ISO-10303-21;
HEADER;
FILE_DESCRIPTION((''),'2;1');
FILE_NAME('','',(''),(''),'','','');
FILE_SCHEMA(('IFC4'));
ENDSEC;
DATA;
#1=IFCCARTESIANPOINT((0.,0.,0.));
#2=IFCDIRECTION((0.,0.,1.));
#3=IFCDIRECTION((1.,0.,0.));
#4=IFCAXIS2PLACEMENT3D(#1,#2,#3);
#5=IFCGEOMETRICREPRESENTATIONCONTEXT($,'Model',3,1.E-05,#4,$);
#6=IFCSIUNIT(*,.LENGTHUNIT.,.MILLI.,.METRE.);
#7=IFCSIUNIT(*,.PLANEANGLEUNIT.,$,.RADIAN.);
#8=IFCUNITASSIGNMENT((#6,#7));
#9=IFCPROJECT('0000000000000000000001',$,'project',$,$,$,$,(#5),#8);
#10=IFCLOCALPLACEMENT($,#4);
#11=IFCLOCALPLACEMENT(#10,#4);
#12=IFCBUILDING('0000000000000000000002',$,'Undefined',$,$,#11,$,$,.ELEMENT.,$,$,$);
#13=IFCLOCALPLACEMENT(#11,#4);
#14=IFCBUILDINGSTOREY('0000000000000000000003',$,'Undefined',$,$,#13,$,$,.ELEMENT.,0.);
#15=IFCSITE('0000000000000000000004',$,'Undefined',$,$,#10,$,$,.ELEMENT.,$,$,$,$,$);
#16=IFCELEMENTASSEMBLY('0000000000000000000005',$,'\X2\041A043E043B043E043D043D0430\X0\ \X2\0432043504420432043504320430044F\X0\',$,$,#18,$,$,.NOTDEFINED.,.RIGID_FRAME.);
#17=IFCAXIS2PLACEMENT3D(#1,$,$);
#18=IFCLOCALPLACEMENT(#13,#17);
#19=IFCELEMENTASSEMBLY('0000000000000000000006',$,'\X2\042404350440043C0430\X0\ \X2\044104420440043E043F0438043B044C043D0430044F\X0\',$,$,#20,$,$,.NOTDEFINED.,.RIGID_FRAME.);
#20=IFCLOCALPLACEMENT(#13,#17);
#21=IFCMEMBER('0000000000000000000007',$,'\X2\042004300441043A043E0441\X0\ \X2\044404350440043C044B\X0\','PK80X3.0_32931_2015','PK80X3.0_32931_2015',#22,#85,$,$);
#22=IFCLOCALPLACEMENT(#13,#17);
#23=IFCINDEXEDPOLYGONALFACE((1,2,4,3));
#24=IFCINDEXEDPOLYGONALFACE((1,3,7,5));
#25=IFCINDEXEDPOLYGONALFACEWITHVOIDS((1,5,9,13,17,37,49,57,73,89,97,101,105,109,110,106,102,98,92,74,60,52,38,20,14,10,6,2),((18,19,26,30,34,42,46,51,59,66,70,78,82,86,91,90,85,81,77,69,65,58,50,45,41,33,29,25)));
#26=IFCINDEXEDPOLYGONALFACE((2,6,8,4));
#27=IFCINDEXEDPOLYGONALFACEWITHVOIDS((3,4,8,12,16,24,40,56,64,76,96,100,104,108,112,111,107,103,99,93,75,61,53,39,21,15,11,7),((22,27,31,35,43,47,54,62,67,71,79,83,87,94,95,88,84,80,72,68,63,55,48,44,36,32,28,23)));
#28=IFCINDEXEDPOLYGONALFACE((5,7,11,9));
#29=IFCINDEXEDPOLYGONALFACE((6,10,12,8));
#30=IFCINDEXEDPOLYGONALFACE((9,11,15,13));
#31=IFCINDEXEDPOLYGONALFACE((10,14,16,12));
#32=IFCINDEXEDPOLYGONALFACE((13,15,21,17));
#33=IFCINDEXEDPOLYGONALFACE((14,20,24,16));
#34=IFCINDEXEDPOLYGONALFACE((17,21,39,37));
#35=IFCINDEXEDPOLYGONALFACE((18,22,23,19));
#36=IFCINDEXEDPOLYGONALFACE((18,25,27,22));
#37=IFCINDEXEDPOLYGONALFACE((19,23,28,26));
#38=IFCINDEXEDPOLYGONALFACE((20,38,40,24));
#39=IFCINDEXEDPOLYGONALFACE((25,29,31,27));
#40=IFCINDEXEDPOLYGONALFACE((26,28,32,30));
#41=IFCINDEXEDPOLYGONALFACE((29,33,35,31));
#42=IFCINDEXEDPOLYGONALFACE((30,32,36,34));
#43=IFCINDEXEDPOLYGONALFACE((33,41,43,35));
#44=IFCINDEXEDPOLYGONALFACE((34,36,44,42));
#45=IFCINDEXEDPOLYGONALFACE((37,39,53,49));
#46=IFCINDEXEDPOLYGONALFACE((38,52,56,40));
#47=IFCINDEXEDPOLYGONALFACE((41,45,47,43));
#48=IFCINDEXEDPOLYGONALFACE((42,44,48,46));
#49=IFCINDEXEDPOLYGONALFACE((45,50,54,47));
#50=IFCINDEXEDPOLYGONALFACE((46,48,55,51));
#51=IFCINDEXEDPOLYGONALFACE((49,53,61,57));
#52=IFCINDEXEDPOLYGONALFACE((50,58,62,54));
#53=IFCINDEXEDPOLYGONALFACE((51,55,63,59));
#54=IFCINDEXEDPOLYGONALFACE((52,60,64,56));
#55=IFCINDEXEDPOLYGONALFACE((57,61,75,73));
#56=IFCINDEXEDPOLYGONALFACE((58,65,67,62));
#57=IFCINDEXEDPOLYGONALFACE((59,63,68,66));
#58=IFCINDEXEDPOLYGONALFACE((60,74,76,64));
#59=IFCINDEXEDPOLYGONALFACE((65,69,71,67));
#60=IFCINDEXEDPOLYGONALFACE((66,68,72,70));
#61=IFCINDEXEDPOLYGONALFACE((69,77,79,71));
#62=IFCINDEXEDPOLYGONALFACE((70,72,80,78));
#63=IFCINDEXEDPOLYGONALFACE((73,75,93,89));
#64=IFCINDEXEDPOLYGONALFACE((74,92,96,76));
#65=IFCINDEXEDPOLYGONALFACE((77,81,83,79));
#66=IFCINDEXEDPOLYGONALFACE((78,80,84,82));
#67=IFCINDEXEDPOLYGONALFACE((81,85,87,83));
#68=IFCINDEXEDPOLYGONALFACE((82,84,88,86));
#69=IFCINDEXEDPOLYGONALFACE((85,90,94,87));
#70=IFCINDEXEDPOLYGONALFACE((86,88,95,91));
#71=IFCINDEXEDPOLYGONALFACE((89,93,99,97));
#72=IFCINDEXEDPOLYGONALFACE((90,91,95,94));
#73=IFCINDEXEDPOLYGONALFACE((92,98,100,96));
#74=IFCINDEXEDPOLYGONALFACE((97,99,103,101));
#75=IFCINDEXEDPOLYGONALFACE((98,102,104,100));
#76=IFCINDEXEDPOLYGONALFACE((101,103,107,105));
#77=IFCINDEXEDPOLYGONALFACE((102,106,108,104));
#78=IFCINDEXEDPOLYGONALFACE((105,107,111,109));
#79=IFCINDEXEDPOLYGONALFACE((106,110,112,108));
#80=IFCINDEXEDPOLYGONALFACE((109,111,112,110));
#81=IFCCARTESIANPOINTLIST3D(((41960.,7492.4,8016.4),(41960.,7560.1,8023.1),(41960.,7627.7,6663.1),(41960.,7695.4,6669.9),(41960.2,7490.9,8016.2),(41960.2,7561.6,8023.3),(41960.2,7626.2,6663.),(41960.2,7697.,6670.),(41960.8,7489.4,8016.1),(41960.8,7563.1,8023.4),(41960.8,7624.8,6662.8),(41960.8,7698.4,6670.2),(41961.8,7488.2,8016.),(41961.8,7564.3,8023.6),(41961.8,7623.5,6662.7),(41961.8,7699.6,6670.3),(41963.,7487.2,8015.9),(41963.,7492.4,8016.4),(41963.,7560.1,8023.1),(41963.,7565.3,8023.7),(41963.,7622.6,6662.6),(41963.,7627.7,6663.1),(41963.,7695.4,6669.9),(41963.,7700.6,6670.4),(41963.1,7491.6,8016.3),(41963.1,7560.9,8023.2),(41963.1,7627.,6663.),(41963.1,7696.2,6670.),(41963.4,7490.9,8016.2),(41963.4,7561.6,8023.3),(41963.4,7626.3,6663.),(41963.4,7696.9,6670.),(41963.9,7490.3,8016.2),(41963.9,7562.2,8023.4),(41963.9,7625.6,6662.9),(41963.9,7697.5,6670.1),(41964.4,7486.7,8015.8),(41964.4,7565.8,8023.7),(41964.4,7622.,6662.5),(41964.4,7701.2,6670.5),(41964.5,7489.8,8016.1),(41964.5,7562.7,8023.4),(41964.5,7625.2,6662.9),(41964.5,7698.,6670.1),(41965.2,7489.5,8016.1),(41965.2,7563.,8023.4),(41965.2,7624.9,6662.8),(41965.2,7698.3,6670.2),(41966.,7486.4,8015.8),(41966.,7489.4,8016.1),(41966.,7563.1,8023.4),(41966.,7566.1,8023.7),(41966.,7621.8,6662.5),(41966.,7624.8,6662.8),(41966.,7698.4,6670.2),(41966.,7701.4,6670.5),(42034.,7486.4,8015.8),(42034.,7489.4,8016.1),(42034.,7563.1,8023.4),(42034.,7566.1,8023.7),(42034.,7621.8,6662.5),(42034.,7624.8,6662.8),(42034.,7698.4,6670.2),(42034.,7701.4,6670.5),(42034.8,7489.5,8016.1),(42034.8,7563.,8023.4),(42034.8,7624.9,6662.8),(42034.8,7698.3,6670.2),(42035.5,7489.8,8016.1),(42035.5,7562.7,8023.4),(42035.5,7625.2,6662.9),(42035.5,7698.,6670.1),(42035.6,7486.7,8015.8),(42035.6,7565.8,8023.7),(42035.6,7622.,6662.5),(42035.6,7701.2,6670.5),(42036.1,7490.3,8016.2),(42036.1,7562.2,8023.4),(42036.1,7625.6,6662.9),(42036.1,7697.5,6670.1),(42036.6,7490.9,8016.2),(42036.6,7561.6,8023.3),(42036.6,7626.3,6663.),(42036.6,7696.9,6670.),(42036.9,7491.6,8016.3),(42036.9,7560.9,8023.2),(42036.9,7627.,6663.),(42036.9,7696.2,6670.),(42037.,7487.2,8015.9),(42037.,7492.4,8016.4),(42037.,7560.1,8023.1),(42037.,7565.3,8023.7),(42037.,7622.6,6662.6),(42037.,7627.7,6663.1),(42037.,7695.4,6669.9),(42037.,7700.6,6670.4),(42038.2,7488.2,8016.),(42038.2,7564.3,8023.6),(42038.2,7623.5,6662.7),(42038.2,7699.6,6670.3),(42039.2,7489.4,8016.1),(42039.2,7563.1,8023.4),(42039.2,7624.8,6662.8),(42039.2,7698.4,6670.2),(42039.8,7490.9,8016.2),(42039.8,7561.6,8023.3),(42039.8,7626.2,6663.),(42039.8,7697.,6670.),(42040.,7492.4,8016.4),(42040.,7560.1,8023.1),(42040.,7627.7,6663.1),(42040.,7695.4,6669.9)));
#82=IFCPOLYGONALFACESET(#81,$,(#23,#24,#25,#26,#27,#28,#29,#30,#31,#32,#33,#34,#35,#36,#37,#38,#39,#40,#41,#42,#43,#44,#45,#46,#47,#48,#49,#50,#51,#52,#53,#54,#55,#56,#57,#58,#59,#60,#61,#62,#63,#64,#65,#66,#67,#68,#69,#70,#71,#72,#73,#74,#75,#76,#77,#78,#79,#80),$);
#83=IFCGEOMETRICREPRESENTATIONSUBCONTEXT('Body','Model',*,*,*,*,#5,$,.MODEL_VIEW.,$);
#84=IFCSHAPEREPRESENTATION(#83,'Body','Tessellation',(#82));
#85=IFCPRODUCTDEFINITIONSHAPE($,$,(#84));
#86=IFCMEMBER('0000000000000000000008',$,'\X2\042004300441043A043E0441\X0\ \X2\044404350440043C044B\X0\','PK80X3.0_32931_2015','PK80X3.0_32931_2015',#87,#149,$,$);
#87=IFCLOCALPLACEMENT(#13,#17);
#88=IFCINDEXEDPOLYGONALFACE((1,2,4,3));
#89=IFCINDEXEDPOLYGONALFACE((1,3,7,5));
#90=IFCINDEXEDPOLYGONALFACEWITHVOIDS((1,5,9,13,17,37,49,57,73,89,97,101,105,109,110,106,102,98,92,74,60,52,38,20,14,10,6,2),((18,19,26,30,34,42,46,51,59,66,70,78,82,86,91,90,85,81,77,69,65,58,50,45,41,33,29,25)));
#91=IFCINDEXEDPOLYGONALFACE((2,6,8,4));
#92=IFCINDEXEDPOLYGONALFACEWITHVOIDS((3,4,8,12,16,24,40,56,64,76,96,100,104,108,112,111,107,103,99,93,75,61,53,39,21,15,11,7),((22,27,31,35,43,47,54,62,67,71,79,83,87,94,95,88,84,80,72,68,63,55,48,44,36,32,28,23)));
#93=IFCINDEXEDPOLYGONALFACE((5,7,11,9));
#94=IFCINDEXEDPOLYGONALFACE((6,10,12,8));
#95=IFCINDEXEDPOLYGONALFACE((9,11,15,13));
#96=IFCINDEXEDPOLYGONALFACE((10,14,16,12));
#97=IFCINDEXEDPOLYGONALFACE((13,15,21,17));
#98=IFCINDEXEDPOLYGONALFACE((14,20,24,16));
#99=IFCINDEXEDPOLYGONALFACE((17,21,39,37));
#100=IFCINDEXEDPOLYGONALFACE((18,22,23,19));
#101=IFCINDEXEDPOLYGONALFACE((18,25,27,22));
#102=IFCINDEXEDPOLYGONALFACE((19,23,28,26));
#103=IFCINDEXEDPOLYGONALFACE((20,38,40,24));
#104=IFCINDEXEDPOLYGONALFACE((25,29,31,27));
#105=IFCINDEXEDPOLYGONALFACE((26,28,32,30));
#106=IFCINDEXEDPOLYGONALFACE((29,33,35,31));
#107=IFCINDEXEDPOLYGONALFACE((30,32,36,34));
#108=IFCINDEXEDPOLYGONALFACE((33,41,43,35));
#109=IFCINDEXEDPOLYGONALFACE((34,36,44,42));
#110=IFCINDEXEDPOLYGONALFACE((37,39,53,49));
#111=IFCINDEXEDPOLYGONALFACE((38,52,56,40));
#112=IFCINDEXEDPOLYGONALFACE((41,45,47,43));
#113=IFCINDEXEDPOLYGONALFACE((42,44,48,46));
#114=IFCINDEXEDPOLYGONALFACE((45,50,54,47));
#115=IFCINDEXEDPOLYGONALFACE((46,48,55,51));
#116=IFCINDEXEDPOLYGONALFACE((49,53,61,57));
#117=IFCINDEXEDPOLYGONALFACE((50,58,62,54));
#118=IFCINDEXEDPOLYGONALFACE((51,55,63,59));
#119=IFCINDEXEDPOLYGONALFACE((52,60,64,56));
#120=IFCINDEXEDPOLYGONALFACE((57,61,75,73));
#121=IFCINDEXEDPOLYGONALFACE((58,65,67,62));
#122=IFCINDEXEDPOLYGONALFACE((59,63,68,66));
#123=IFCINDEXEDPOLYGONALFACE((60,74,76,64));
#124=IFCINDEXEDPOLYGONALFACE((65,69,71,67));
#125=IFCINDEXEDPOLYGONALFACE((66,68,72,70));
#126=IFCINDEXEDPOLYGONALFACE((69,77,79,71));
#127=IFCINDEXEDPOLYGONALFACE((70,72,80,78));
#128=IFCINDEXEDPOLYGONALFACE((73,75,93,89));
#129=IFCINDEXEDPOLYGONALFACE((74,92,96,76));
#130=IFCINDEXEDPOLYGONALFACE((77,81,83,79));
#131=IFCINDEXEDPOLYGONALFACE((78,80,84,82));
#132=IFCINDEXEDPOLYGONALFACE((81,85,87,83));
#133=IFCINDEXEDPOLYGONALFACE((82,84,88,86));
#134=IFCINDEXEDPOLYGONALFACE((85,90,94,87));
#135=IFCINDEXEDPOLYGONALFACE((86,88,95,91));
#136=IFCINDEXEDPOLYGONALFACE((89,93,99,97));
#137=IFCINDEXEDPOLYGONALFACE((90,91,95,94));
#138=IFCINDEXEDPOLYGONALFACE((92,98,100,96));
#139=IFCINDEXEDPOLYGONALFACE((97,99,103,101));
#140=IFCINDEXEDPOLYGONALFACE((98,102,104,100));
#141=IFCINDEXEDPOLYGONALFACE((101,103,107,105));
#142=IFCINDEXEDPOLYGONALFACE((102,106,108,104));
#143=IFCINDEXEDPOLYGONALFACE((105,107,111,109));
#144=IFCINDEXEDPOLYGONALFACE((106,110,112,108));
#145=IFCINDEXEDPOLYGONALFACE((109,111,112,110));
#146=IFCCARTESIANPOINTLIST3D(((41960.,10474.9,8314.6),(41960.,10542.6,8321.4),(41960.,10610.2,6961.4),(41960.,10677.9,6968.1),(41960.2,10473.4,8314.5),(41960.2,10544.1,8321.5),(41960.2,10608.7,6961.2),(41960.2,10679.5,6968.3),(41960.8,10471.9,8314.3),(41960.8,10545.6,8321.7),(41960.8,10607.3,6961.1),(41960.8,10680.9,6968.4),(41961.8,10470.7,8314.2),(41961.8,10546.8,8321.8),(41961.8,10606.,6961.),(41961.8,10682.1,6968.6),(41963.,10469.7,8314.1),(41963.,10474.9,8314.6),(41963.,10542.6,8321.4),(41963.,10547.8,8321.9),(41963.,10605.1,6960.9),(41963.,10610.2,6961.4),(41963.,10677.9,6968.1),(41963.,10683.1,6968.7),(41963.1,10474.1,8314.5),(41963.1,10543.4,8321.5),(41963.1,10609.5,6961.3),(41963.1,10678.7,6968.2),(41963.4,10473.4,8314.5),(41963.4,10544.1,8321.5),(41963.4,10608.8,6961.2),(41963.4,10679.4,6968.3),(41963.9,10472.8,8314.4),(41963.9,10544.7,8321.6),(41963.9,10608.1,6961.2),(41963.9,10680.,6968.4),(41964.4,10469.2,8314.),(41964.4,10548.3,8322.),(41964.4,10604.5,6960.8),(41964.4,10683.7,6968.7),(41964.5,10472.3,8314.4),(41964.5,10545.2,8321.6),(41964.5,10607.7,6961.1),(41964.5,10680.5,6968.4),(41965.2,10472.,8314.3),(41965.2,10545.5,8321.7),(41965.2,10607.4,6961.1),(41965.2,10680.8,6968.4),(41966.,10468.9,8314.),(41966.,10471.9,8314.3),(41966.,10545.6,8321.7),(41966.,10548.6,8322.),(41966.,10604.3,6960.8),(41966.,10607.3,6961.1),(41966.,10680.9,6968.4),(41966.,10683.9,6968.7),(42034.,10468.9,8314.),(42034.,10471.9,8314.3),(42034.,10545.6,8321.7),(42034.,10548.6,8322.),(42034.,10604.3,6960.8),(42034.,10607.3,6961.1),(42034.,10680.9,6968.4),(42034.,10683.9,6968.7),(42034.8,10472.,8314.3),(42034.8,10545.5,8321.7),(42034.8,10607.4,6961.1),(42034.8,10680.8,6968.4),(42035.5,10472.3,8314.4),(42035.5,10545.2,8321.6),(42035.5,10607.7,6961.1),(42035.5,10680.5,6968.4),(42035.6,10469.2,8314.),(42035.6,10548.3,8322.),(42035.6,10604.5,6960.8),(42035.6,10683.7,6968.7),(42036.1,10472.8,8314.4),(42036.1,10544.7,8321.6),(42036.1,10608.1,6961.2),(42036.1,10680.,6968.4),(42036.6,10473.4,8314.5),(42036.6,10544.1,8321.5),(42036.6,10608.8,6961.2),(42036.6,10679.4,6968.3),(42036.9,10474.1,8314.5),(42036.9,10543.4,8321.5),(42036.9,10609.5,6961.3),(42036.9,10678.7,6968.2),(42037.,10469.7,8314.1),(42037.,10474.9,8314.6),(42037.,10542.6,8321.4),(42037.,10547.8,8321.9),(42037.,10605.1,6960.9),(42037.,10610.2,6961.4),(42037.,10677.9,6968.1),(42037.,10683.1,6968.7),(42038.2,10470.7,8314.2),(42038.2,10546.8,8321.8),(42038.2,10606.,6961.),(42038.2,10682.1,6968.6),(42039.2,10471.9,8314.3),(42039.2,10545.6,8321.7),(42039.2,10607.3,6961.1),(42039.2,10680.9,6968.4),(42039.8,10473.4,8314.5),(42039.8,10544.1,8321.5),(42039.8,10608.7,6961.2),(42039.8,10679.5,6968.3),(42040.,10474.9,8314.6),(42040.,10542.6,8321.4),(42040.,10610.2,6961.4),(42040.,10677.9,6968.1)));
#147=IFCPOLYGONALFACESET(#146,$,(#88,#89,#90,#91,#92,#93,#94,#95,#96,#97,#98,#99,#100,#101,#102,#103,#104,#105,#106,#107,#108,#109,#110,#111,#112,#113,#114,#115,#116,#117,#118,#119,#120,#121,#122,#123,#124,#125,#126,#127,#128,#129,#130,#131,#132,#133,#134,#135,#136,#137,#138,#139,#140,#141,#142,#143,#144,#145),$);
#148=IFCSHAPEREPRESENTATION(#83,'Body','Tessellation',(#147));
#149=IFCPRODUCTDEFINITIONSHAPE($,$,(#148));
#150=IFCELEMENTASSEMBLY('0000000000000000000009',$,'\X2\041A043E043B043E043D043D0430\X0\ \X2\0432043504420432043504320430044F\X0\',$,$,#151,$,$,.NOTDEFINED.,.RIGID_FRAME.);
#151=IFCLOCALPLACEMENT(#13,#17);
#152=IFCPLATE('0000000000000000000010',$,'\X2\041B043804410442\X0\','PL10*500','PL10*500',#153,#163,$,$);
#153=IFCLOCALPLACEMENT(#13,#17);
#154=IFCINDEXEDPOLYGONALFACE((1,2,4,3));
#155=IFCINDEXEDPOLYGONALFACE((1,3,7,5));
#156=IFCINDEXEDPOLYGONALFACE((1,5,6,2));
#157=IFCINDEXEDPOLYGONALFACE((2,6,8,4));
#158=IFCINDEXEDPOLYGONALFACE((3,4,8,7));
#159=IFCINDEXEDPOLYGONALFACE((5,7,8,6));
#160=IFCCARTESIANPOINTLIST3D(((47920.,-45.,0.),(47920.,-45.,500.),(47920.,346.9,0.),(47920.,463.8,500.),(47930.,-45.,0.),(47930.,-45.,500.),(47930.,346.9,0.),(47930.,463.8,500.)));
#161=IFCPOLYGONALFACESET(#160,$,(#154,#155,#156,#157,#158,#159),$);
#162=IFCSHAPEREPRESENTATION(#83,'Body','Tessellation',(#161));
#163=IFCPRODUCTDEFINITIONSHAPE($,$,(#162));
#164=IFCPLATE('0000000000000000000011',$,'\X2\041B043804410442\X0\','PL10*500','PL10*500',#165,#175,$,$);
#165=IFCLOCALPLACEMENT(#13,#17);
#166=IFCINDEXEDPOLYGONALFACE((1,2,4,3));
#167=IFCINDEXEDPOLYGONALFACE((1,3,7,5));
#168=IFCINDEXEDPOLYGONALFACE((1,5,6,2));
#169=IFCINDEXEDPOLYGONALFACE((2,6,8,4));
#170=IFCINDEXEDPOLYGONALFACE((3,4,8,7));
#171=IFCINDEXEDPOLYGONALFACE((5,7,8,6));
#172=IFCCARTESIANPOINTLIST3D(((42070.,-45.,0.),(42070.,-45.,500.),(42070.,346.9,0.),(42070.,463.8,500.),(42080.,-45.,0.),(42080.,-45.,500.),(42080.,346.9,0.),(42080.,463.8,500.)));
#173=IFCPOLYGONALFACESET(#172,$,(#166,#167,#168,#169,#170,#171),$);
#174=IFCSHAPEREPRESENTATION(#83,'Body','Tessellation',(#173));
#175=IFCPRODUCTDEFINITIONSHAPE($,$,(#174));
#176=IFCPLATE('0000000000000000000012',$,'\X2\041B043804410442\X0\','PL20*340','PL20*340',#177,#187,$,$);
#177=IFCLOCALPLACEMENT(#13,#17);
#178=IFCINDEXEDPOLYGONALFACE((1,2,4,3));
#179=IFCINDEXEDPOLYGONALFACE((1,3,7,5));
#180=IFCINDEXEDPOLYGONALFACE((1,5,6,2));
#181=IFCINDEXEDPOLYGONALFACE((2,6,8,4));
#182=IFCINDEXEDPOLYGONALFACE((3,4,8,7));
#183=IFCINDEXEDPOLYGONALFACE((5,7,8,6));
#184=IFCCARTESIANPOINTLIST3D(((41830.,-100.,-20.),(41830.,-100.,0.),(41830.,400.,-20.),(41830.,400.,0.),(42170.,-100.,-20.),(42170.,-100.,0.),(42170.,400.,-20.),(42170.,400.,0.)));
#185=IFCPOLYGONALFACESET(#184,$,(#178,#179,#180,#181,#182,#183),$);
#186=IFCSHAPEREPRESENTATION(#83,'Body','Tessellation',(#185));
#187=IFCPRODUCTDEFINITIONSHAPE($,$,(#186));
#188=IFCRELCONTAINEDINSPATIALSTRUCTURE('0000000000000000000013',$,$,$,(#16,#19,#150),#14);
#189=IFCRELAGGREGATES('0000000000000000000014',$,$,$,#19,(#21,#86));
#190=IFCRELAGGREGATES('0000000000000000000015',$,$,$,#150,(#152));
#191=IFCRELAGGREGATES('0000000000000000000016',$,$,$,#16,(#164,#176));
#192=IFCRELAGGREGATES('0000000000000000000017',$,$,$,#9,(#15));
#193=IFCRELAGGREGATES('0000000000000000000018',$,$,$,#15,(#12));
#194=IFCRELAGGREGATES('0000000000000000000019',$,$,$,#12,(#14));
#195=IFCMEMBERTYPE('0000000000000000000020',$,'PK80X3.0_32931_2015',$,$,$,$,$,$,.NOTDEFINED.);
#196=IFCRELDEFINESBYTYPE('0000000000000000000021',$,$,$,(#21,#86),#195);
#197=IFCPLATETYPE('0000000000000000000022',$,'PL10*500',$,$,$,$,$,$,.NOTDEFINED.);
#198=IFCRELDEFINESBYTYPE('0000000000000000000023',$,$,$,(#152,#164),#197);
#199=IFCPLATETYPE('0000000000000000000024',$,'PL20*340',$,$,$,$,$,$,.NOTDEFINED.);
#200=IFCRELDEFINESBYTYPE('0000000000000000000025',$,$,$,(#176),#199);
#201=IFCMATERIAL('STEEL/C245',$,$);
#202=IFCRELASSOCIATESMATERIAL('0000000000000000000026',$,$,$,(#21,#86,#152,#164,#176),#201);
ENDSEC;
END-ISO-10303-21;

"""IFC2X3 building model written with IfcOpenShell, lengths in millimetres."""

from ifc_helpers import new_model, si_unit, frame, origin_with_axes, origin_2d_with_axis, place, context, subcontext, project, spatial, polyline, hollow_rectangle, outline, extrude, material, type_object, element, aggregate, save


model = new_model("IFC2X3")

# Units and contexts
model_context = context("Model", 3, precision=1e-05, world=origin_with_axes())
body_context = subcontext(model_context, "Body", "Model", "MODEL_VIEW")
ifc_project = project(units=[si_unit("LENGTHUNIT", "METRE", prefix="MILLI"), si_unit("PLANEANGLEUNIT", "RADIAN")], contexts=[model_context])

# Site, building, storey
site_placement = place(None, origin_with_axes())
site = spatial("IfcSite", under=ifc_project, at=site_placement, Name="Undefined", CompositionType="ELEMENT")
building_placement = place(site_placement, origin_with_axes())
building = spatial("IfcBuilding", under=site, at=building_placement, Name="Undefined", CompositionType="ELEMENT")
storey_placement = place(building_placement, origin_with_axes())
storey = spatial("IfcBuildingStorey", under=building, at=storey_placement, Name="Undefined", CompositionType="ELEMENT", Elevation=0.0)

# Shared definitions
ifc_material_1 = material(Name="STEEL/C245")

# Element assembly
assembly_1_placement = place(storey_placement, origin_with_axes())
assembly_1 = element("IfcElementAssembly", 1, at=assembly_1_placement, inside=storey, Name="Колонна ветвевая", AssemblyPlace="NOTDEFINED", PredefinedType="RIGID_FRAME")
member_type_1 = type_object("IfcMemberType", Name="PK80X3.0_32931_2015", PredefinedType="NOTDEFINED")

# Element assembly, members
assembly_2_placement = place(storey_placement, origin_with_axes())
assembly_2 = element("IfcElementAssembly", 2, at=assembly_2_placement, inside=storey, Name="Ферма стропильная", AssemblyPlace="NOTDEFINED", PredefinedType="RIGID_FRAME")
member_1_placement = place(assembly_2_placement, frame((42000.0, 7526.3, 8019.8), z_axis=(0.0, 0.995037, 0.099504), x_axis=(0.0, 0.099504, -0.995037)))
member_1 = element("IfcMember", 3, at=member_1_placement, type_object=member_type_1, material=ifc_material_1, Name="Раскос фермы", Description="PK80X3.0_32931_2015", ObjectType="PK80X3.0_32931_2015", context=body_context, shape_type="SweptSolid", body=[
    extrude(hollow_rectangle(XDim=80.0, YDim=80.0, WallThickness=3.0, InnerFilletRadius=3.0, OuterFilletRadius=6.0, at=origin_2d_with_axis()), frame((1360.0, 0.0, 0.0), z_axis=(-1.0, 0.0, 0.0), x_axis=(0.0, -1.0, 0.0)), (0.0, 0.0, 1.0), 1360.0),
])
member_2_placement = place(assembly_2_placement, frame((42000.0, 10508.8, 8318.0), z_axis=(0.0, 0.995037, 0.099504), x_axis=(0.0, 0.099504, -0.995037)))
member_2 = element("IfcMember", 4, at=member_2_placement, type_object=member_type_1, material=ifc_material_1, Name="Раскос фермы", Description="PK80X3.0_32931_2015", ObjectType="PK80X3.0_32931_2015", context=body_context, shape_type="SweptSolid", body=[
    extrude(hollow_rectangle(XDim=80.0, YDim=80.0, WallThickness=3.0, InnerFilletRadius=3.0, OuterFilletRadius=6.0, at=origin_2d_with_axis()), frame((1360.0, 0.0, 0.0), z_axis=(-1.0, 0.0, 0.0), x_axis=(0.0, -1.0, 0.0)), (0.0, 0.0, 1.0), 1360.0),
])
aggregate(assembly_2, [member_1, member_2])

# Element assembly, plate
assembly_3_placement = place(storey_placement, origin_with_axes())
assembly_3 = element("IfcElementAssembly", 5, at=assembly_3_placement, inside=storey, Name="Колонна ветвевая", AssemblyPlace="NOTDEFINED", PredefinedType="RIGID_FRAME")
plate_type_1 = type_object("IfcPlateType", Name="PL10*500", PredefinedType="NOTDEFINED")
plate_1_placement = place(assembly_3_placement, frame((47925.0, -45.0, 500.0), z_axis=(1.0, 0.0, 0.0), x_axis=(0.0, 0.0, -1.0)))
plate_1 = element("IfcPlate", 6, at=plate_1_placement, type_object=plate_type_1, material=ifc_material_1, Name="Лист", Description="PL10*500", ObjectType="PL10*500", context=body_context, shape_type="SweptSolid", body=[
    extrude(outline(polyline([(0.0, 0.0), (500.0, 0.0), (500.0, 391.9), (0.0, 508.8), (0.0, 0.0)])), frame((0.0, 0.0, -5.0), z_axis=(0.0, 0.0, 1.0), x_axis=(1.0, 0.0, 0.0)), (0.0, 0.0, 1.0), 10.0),
])
aggregate(assembly_3, [plate_1])

# Plates
plate_2_placement = place(assembly_1_placement, frame((42075.0, -45.0, 500.0), z_axis=(1.0, 0.0, 0.0), x_axis=(0.0, 0.0, -1.0)))
plate_2 = element("IfcPlate", 7, at=plate_2_placement, type_object=plate_type_1, material=ifc_material_1, Name="Лист", Description="PL10*500", ObjectType="PL10*500", context=body_context, shape_type="SweptSolid", body=[
    extrude(outline(polyline([(0.0, 0.0), (500.0, 0.0), (500.0, 391.9), (0.0, 508.8), (0.0, 0.0)])), frame((0.0, 0.0, -5.0), z_axis=(0.0, 0.0, 1.0), x_axis=(1.0, 0.0, 0.0)), (0.0, 0.0, 1.0), 10.0),
])
plate_type_2 = type_object("IfcPlateType", Name="PL20*340", PredefinedType="NOTDEFINED")
plate_3_placement = place(assembly_1_placement, frame((42170.0, -100.0, -10.0), z_axis=(0.0, 0.0, 1.0), x_axis=(0.0, 1.0, 0.0)))
plate_3 = element("IfcPlate", 8, at=plate_3_placement, type_object=plate_type_2, material=ifc_material_1, Name="Лист", Description="PL20*340", ObjectType="PL20*340", context=body_context, shape_type="SweptSolid", body=[
    extrude(outline(polyline([(0.0, 0.0), (500.0, 0.0), (500.0, 340.0), (0.0, 340.0), (0.0, 0.0)])), frame((0.0, 0.0, -10.0), z_axis=(0.0, 0.0, 1.0), x_axis=(1.0, 0.0, 0.0)), (0.0, 0.0, 1.0), 20.0),
])
aggregate(assembly_1, [plate_2, plate_3])

save(model, "model.ifc")
